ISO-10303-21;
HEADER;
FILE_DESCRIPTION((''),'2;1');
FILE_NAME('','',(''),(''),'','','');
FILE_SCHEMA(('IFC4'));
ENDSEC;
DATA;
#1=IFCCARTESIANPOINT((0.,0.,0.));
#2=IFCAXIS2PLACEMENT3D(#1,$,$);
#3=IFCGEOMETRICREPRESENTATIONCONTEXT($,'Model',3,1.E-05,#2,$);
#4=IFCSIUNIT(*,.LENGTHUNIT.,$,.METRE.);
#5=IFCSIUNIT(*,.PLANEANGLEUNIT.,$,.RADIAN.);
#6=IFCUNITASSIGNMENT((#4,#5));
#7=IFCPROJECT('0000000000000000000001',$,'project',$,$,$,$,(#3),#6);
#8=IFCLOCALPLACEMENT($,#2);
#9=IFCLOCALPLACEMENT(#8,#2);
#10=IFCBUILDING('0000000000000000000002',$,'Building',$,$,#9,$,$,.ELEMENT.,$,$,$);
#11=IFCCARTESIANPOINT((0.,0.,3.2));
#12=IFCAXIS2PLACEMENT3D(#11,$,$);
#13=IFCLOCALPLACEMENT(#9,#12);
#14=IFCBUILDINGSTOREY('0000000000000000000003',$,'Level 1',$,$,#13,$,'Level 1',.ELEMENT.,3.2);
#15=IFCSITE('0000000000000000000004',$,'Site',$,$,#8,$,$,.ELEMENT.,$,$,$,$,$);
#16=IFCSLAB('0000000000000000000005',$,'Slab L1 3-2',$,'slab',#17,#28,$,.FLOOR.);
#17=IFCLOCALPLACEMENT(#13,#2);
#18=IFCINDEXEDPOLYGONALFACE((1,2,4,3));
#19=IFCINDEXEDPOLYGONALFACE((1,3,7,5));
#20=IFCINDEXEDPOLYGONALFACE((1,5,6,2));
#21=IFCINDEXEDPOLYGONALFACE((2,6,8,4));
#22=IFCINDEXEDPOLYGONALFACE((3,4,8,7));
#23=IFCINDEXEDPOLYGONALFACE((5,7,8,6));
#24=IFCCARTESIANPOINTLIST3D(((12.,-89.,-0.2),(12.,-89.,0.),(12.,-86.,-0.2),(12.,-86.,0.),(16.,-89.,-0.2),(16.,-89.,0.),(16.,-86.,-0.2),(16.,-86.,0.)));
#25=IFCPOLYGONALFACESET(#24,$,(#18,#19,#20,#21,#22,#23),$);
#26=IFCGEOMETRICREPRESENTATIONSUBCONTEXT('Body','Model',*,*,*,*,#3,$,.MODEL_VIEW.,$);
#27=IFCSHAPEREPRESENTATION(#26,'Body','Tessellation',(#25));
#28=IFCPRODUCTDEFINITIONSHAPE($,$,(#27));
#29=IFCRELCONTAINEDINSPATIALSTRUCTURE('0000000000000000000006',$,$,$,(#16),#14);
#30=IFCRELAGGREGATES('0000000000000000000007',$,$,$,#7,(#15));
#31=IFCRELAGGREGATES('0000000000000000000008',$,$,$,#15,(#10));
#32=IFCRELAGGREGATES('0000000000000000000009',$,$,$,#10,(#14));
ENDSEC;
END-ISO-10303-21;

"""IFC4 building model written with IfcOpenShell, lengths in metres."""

from ifc_helpers import new_model, si_unit, frame, origin, place, context, subcontext, project, spatial, polyline, outline, extrude, element, save


model = new_model("IFC4")

# Units and contexts
model_context = context("Model", 3, precision=1e-05, world=origin())
body_context = subcontext(model_context, "Body", "Model", "MODEL_VIEW")
ifc_project = project(units=[si_unit("LENGTHUNIT", "METRE"), si_unit("PLANEANGLEUNIT", "RADIAN")], contexts=[model_context])

# Site, building, storey
site_placement = place(None, origin())
site = spatial("IfcSite", under=ifc_project, at=site_placement, Name="Site", CompositionType="ELEMENT")
building_placement = place(site_placement, origin())
building = spatial("IfcBuilding", under=site, at=building_placement, Name="Building", CompositionType="ELEMENT")
storey_placement = place(building_placement, frame((0.0, 0.0, 3.2)))
storey = spatial("IfcBuildingStorey", under=building, at=storey_placement, Name="Level 1", LongName="Level 1", CompositionType="ELEMENT", Elevation=3.2)

# Slab
slab_1_placement = place(storey_placement, frame((0.0, 0.0, -0.2)))
element("IfcSlab", 1, at=slab_1_placement, inside=storey, Name="Slab L1 3-2", ObjectType="slab", PredefinedType="FLOOR", context=body_context, shape_type="SweptSolid", body=[
    extrude(outline(polyline([(12.0, -89.0), (16.0, -89.0), (16.0, -86.0), (12.0, -86.0), (12.0, -89.0)])), origin(), (0.0, 0.0, 1.0), 0.2),
])

save(model, "model.ifc")
